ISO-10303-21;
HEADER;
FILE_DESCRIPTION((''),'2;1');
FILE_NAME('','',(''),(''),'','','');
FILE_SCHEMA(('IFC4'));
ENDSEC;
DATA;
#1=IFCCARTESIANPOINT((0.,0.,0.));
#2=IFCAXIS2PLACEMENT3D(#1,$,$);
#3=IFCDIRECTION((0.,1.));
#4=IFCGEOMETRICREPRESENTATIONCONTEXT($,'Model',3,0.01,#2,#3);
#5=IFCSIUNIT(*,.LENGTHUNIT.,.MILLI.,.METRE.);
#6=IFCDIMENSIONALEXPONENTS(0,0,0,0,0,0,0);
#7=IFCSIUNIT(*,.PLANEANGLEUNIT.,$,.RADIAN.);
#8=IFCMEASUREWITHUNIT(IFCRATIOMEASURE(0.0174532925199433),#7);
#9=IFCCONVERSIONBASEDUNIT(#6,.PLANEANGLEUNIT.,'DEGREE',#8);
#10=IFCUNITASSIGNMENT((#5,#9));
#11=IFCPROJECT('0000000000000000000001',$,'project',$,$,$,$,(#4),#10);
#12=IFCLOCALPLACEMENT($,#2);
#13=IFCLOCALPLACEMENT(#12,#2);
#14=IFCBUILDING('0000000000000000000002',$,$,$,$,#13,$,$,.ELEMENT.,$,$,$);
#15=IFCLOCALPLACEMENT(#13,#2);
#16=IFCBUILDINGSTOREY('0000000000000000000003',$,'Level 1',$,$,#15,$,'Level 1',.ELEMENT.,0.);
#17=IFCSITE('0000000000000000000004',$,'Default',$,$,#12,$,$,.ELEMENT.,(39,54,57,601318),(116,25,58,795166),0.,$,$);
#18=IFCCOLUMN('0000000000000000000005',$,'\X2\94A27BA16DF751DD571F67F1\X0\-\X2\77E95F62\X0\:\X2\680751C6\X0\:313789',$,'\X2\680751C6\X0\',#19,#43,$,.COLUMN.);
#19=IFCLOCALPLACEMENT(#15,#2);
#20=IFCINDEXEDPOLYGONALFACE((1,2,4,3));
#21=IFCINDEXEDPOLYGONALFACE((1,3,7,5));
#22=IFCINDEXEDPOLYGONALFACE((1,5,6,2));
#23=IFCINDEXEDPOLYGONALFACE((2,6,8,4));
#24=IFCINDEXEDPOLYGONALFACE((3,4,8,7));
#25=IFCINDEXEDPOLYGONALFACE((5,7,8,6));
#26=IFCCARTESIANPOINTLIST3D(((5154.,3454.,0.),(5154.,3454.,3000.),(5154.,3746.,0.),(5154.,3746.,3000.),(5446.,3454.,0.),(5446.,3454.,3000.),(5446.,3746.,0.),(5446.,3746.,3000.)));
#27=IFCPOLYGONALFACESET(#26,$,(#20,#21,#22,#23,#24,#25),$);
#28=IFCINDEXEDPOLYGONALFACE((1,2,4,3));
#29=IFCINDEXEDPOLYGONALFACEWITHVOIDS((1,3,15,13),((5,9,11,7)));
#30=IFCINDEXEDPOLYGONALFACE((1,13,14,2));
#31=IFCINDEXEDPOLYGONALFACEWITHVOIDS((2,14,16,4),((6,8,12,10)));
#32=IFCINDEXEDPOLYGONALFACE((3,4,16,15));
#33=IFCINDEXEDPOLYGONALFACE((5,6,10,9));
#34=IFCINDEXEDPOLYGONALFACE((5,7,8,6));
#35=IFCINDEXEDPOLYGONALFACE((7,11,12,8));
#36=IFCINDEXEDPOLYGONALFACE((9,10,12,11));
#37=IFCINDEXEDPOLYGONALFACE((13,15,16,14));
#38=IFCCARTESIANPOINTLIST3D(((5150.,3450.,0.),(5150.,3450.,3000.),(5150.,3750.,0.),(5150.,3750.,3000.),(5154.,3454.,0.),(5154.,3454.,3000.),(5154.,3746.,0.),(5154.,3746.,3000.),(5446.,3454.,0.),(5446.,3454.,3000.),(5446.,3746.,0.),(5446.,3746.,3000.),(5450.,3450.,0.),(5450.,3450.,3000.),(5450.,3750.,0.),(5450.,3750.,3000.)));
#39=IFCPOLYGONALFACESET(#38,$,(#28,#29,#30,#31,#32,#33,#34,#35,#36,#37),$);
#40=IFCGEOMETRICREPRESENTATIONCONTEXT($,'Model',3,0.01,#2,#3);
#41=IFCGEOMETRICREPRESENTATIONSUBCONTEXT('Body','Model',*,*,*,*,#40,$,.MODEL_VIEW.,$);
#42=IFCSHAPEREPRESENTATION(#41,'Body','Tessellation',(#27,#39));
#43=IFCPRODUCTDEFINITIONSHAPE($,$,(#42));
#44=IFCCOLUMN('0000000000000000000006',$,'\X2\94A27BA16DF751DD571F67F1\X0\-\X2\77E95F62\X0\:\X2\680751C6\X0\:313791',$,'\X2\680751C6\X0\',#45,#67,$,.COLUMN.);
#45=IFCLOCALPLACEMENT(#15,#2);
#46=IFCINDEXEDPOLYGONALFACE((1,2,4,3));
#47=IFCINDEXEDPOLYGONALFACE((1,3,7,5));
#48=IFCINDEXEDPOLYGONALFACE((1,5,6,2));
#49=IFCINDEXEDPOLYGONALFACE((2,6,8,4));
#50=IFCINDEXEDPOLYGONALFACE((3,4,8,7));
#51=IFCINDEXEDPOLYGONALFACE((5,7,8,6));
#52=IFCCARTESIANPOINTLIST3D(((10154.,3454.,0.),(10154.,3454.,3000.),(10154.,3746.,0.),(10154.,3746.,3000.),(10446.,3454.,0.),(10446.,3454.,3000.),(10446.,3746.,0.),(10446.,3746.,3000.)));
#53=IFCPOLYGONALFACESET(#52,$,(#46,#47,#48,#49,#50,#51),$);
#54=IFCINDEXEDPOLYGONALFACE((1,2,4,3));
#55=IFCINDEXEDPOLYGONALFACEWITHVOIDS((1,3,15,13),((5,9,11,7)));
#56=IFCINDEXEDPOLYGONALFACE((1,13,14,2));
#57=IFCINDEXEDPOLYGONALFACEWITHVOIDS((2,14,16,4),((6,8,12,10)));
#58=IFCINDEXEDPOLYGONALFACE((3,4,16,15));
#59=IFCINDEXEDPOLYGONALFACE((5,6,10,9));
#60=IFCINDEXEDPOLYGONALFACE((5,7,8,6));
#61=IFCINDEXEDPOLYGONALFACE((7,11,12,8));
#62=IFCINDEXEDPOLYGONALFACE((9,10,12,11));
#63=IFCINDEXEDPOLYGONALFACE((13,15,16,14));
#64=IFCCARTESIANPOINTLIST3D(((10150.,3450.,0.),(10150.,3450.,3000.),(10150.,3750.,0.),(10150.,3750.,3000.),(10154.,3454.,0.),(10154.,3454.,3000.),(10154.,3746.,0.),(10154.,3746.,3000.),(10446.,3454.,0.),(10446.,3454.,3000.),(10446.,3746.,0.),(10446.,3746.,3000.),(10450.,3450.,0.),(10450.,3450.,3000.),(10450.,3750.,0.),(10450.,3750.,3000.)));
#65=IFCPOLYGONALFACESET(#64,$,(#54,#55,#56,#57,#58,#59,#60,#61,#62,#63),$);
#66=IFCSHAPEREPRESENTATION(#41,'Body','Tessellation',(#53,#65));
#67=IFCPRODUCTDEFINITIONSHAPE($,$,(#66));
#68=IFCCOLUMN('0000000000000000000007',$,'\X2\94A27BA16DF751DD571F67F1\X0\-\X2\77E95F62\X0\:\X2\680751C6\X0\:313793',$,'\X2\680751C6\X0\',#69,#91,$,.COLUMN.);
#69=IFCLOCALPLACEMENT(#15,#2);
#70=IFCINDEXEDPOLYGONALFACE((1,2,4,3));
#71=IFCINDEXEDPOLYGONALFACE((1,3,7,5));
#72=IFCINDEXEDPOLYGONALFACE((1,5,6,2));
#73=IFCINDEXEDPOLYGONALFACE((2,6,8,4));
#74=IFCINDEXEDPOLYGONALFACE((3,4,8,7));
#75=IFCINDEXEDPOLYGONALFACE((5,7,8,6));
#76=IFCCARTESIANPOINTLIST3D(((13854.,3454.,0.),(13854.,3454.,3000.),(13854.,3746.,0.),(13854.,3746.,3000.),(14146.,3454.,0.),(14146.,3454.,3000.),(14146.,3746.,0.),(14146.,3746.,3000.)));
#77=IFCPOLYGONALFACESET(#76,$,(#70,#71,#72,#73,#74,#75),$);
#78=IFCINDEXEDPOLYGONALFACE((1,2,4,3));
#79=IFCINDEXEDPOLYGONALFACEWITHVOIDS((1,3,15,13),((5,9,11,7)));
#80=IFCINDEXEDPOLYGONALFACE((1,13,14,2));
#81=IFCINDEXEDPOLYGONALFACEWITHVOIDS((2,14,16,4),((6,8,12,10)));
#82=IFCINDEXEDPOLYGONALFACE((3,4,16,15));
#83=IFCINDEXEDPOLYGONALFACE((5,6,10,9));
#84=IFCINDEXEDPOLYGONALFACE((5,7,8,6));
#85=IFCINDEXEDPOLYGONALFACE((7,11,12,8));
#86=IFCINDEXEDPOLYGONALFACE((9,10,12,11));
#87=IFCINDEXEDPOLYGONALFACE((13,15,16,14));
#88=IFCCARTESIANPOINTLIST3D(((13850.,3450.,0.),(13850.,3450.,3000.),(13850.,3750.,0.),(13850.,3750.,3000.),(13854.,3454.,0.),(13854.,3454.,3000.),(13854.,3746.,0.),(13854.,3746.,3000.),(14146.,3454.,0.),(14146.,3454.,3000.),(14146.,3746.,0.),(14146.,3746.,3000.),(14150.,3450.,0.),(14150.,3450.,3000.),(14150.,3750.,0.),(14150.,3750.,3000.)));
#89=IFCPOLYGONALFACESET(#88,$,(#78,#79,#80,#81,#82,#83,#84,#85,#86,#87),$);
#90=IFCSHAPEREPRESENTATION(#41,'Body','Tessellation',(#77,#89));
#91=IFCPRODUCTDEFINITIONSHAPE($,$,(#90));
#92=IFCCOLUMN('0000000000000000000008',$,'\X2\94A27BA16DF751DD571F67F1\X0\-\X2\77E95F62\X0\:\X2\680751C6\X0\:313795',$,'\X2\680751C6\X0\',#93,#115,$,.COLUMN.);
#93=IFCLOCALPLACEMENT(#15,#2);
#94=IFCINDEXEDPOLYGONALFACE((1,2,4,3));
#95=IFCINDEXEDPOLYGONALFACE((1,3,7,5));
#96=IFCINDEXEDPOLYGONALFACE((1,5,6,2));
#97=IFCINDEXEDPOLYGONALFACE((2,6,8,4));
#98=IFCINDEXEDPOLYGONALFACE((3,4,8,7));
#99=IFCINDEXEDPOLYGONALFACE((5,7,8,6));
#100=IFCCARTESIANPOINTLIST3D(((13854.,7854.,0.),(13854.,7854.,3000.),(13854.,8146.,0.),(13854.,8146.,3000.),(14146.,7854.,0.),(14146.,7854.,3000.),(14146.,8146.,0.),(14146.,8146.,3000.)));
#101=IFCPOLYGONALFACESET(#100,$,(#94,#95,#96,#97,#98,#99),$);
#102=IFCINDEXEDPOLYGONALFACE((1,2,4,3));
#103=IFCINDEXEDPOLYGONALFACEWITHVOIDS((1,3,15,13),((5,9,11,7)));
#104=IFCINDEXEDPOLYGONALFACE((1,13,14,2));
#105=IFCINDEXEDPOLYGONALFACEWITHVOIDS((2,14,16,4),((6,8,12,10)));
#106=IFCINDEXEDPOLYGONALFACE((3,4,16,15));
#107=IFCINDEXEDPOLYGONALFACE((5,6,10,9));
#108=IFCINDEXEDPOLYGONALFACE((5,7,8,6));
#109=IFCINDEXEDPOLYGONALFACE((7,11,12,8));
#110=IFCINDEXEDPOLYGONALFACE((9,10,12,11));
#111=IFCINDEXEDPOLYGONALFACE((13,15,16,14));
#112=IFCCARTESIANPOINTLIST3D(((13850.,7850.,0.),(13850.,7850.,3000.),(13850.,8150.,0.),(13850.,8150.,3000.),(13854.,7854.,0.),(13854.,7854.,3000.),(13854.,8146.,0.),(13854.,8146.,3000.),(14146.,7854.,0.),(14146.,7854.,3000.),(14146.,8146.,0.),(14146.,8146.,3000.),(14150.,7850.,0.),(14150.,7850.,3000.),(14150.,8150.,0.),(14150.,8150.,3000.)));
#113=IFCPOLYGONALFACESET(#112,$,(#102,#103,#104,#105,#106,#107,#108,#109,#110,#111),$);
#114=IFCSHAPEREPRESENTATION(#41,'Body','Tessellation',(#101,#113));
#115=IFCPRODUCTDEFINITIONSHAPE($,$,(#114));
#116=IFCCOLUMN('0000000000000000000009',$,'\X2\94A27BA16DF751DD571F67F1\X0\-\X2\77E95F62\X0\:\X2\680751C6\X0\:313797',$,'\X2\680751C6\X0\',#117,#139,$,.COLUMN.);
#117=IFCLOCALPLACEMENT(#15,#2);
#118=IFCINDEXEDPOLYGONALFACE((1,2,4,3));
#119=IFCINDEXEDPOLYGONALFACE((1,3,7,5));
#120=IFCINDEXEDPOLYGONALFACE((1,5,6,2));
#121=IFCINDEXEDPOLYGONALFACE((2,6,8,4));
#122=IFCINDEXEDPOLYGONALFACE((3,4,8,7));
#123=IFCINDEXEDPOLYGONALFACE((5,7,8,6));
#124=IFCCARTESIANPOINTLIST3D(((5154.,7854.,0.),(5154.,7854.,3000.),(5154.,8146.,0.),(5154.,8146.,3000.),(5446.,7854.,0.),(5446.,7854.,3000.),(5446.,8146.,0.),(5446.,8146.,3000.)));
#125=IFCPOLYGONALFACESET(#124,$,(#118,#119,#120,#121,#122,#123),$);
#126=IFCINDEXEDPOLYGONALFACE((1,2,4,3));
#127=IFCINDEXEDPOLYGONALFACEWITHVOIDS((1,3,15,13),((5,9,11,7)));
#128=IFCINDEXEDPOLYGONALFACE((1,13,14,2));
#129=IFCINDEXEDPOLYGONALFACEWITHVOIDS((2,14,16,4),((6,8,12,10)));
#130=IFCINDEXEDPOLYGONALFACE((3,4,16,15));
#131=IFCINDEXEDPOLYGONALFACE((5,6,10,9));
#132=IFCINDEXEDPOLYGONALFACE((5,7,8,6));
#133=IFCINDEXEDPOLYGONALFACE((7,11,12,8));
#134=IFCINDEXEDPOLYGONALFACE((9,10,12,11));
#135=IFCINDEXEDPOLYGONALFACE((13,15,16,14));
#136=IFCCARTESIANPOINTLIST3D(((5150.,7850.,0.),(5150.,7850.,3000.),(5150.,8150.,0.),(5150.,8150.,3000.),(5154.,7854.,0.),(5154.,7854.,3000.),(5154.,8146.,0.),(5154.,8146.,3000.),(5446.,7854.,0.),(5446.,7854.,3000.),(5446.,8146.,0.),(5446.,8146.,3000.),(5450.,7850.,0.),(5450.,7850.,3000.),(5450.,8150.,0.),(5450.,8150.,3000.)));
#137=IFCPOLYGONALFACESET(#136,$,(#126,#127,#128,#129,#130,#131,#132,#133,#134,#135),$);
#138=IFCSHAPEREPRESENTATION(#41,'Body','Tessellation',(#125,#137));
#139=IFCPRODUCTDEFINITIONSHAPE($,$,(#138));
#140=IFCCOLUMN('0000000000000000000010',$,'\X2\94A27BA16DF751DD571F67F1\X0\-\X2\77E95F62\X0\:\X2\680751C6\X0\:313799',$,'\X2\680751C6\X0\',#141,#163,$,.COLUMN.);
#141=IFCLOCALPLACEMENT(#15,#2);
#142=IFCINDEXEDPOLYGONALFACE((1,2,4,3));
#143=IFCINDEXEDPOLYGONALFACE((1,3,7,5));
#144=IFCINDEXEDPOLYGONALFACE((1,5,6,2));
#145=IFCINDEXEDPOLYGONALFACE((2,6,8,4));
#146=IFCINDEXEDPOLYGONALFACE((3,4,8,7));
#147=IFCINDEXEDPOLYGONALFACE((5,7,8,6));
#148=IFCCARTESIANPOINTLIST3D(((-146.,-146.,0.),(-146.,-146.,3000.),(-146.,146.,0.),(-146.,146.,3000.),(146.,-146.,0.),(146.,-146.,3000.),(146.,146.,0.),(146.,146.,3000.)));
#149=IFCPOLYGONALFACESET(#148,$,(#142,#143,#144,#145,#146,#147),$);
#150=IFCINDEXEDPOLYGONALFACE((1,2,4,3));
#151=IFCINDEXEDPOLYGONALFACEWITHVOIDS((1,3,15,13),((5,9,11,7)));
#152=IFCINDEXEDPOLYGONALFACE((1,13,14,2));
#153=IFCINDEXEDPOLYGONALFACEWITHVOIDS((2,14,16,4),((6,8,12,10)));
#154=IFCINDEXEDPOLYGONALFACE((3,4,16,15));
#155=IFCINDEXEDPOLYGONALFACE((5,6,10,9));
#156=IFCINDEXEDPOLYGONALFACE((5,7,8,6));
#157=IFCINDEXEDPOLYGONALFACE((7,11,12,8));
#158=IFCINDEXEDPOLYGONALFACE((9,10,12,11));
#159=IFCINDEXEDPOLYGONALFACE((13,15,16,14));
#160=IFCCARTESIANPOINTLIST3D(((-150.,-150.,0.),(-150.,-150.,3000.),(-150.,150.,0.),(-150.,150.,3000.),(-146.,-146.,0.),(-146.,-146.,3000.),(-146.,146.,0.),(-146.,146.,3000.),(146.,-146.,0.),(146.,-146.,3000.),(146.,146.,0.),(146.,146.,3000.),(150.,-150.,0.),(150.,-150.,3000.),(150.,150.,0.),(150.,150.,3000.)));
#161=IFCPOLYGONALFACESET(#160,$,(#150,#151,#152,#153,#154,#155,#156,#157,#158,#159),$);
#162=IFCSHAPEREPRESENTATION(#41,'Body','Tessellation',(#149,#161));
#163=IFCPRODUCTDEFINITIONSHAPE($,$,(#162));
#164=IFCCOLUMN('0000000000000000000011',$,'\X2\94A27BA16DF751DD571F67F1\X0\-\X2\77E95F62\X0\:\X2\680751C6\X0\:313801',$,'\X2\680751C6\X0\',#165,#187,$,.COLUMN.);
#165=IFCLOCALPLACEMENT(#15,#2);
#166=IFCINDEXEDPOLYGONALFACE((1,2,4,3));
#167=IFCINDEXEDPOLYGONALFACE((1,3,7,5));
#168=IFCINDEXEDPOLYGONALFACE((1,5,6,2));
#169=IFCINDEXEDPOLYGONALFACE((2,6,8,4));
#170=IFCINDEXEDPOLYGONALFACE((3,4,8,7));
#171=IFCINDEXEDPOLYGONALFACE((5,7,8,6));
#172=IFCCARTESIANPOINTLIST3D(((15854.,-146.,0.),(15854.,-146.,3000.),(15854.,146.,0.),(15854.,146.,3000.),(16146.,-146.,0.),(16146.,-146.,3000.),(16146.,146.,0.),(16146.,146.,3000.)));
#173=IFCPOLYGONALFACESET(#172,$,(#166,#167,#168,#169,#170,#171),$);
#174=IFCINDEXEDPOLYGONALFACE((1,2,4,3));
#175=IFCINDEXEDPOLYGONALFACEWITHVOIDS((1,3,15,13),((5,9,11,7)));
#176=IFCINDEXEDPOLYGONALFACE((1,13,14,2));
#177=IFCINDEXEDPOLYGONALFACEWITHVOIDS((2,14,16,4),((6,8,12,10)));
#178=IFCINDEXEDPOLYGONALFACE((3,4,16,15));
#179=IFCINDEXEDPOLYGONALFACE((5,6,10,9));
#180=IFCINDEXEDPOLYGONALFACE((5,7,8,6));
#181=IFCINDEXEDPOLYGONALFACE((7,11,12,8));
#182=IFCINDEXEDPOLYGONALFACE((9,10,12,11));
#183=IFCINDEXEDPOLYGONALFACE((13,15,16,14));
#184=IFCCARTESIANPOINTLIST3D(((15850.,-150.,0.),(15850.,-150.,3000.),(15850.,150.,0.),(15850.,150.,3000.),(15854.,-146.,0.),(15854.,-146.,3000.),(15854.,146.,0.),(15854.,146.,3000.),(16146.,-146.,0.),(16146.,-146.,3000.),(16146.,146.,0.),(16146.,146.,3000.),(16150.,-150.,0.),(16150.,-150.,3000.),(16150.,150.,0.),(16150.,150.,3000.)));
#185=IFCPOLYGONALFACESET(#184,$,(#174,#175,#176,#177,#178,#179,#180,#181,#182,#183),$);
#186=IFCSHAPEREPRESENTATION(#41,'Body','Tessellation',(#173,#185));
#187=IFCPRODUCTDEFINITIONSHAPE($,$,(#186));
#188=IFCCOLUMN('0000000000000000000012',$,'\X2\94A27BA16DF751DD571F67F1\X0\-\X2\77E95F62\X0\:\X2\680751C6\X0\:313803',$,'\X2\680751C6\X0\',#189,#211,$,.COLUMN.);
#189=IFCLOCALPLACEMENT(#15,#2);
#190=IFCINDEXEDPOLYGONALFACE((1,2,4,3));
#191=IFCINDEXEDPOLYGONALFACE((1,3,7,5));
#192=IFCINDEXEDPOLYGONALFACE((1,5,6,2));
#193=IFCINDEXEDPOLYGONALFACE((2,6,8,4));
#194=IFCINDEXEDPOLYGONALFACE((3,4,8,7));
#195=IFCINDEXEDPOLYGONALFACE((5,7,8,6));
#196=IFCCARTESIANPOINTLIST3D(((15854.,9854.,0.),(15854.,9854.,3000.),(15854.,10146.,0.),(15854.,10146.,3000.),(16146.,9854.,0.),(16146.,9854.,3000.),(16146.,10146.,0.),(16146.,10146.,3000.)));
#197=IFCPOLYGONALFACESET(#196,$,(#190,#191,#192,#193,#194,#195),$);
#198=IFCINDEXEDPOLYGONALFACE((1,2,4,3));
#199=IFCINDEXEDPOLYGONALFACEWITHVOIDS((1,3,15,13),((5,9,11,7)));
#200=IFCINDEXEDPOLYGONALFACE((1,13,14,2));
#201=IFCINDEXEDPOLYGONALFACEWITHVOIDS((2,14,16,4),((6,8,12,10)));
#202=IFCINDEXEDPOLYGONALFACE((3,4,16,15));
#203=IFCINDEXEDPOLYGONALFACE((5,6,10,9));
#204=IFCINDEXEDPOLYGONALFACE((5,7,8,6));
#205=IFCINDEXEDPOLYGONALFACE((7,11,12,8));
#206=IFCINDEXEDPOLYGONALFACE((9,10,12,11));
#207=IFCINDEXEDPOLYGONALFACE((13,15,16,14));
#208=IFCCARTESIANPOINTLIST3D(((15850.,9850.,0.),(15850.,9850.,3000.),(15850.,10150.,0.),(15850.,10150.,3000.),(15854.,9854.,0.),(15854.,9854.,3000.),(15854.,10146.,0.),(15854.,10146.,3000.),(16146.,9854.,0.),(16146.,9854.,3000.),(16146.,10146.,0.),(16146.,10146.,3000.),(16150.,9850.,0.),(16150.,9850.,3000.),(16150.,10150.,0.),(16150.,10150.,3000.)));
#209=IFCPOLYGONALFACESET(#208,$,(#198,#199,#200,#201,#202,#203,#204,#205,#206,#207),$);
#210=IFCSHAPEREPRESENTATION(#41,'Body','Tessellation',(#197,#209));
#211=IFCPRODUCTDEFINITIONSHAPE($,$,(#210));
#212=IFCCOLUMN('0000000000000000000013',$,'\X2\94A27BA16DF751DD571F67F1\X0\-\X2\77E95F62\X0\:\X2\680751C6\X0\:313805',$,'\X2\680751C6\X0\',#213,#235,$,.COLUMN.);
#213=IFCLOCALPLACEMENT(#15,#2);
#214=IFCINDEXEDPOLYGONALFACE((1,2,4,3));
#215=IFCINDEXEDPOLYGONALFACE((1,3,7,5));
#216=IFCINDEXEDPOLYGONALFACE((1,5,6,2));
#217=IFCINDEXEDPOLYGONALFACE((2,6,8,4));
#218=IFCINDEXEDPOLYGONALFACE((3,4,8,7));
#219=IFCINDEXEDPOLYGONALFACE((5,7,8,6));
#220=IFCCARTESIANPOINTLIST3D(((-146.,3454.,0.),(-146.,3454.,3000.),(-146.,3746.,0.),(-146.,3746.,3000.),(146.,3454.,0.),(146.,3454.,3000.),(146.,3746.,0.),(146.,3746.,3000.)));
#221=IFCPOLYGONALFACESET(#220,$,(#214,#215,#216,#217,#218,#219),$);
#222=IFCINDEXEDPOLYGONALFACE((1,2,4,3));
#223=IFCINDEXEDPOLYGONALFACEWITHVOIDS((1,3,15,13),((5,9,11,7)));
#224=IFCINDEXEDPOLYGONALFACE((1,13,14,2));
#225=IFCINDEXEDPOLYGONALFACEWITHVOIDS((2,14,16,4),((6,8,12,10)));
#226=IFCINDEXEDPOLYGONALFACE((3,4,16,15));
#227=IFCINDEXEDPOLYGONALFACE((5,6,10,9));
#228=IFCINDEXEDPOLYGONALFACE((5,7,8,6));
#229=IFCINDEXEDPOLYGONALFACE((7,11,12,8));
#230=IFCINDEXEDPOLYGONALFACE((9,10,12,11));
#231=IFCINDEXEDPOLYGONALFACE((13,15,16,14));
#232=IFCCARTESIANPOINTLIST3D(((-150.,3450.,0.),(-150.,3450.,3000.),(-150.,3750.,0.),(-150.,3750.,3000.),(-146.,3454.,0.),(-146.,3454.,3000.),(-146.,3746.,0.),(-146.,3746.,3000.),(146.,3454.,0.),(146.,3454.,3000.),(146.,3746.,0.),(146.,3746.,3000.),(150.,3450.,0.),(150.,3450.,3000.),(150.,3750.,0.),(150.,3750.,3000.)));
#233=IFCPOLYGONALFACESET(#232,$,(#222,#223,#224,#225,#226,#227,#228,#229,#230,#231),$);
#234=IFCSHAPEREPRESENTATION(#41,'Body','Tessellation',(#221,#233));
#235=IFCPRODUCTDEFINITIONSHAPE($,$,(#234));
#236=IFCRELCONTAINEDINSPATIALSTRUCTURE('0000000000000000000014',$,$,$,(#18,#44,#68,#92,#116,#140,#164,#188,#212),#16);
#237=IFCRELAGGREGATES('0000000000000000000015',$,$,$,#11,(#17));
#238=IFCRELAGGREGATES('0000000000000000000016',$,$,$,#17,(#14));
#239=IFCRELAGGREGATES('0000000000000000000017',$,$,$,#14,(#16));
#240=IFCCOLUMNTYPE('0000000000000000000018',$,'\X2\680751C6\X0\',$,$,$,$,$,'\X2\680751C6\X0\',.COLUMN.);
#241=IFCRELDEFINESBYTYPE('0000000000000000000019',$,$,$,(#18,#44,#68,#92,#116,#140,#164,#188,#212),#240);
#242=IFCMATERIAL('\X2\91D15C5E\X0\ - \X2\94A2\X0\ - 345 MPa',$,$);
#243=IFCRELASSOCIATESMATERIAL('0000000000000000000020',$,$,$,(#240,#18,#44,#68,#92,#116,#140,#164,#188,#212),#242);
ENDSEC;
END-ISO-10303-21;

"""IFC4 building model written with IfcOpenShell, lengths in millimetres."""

from ifc_helpers import new_model, entity, si_unit, converted_unit, direction, frame, origin, origin_2d_with_axis, place, context, subcontext, project, spatial, polyline, rectangle, outline, extrude, source, transform, mapped, material, type_object, type_shapes, element, save


model = new_model("IFC4")

# Units and contexts
model_context_1 = context("Model", 3, precision=0.01, world=origin(), true_north=direction((0.0, 1.0)))
model_context_2 = context("Model", 3, precision=0.01, world=origin(), true_north=direction((0.0, 1.0)))
body_context = subcontext(model_context_2, "Body", "Model", "MODEL_VIEW")
ifc_project = project(units=[si_unit("LENGTHUNIT", "METRE", prefix="MILLI"), converted_unit("PLANEANGLEUNIT", "DEGREE", entity("IfcRatioMeasure", 0.0174532925199433), si_unit("PLANEANGLEUNIT", "RADIAN"), dimensions=[0, 0, 0, 0, 0, 0, 0])], contexts=[model_context_1])

# Site, building, storey
site_placement = place(None, origin())
site = spatial("IfcSite", under=ifc_project, at=site_placement, Name="Default", CompositionType="ELEMENT", RefLatitude=(39, 54, 57, 601318), RefLongitude=(116, 25, 58, 795166), RefElevation=0.0)
building_placement = place(site_placement, origin())
building = spatial("IfcBuilding", under=site, at=building_placement, CompositionType="ELEMENT")
storey_placement = place(building_placement, origin())
storey = spatial("IfcBuildingStorey", under=building, at=storey_placement, Name="Level 1", LongName="Level 1", CompositionType="ELEMENT", Elevation=0.0)

# Columns
ifc_material = material(Name="金属 - 钢 - 345 MPa")
column_type = type_object("IfcColumnType", Name="标准", ElementType="标准", PredefinedType="COLUMN", material=ifc_material)
shared_shape = source(origin(), body_context, "Body", "SweptSolid", [
    extrude(rectangle(XDim=292.0, YDim=292.0, at=origin_2d_with_axis()), frame((0.0, 0.0, 0.0), z_axis=(0.0, 0.0, 1.0), x_axis=(-1.0, 0.0, 0.0)), (0.0, 0.0, 1.0), 3000.0),
    extrude(outline(polyline([(-150.0, -150.0), (150.0, -150.0), (150.0, 150.0), (-150.0, 150.0), (-150.0, -150.0)]), holes=[polyline([(-146.0, -146.0), (-146.0, 146.0), (146.0, 146.0), (146.0, -146.0), (-146.0, -146.0)])]), frame((0.0, 0.0, 0.0), z_axis=(0.0, 0.0, 1.0), x_axis=(-1.0, 0.0, 0.0)), (0.0, 0.0, 1.0), 3000.0),
])
type_shapes(column_type, [shared_shape])
for number, where, name in (
    (1, (5300.0, 3600.0, 0.0), "钢管混凝土柱-矩形:标准:313789"),
    (2, (10300.0, 3600.0, 0.0), "钢管混凝土柱-矩形:标准:313791"),
    (3, (14000.0, 3600.0, 0.0), "钢管混凝土柱-矩形:标准:313793"),
    (4, (14000.0, 8000.0, 0.0), "钢管混凝土柱-矩形:标准:313795"),
    (5, (5300.0, 8000.0, 0.0), "钢管混凝土柱-矩形:标准:313797"),
    (6, (0.0, 0.0, 0.0), "钢管混凝土柱-矩形:标准:313799"),
    (7, (16000.0, 0.0, 0.0), "钢管混凝土柱-矩形:标准:313801"),
    (8, (16000.0, 10000.0, 0.0), "钢管混凝土柱-矩形:标准:313803"),
    (9, (0.0, 3600.0, 0.0), "钢管混凝土柱-矩形:标准:313805"),
):
    element("IfcColumn", number, at=place(storey_placement, frame(where)), inside=storey, type_object=column_type, material=ifc_material, Name=name, ObjectType="标准", PredefinedType="COLUMN", context=body_context, shape_type="MappedRepresentation", body=[
        mapped(shared_shape, transform((0.0, 0.0, 0.0), scale=1.0)),
    ])

save(model, "model.ifc")
